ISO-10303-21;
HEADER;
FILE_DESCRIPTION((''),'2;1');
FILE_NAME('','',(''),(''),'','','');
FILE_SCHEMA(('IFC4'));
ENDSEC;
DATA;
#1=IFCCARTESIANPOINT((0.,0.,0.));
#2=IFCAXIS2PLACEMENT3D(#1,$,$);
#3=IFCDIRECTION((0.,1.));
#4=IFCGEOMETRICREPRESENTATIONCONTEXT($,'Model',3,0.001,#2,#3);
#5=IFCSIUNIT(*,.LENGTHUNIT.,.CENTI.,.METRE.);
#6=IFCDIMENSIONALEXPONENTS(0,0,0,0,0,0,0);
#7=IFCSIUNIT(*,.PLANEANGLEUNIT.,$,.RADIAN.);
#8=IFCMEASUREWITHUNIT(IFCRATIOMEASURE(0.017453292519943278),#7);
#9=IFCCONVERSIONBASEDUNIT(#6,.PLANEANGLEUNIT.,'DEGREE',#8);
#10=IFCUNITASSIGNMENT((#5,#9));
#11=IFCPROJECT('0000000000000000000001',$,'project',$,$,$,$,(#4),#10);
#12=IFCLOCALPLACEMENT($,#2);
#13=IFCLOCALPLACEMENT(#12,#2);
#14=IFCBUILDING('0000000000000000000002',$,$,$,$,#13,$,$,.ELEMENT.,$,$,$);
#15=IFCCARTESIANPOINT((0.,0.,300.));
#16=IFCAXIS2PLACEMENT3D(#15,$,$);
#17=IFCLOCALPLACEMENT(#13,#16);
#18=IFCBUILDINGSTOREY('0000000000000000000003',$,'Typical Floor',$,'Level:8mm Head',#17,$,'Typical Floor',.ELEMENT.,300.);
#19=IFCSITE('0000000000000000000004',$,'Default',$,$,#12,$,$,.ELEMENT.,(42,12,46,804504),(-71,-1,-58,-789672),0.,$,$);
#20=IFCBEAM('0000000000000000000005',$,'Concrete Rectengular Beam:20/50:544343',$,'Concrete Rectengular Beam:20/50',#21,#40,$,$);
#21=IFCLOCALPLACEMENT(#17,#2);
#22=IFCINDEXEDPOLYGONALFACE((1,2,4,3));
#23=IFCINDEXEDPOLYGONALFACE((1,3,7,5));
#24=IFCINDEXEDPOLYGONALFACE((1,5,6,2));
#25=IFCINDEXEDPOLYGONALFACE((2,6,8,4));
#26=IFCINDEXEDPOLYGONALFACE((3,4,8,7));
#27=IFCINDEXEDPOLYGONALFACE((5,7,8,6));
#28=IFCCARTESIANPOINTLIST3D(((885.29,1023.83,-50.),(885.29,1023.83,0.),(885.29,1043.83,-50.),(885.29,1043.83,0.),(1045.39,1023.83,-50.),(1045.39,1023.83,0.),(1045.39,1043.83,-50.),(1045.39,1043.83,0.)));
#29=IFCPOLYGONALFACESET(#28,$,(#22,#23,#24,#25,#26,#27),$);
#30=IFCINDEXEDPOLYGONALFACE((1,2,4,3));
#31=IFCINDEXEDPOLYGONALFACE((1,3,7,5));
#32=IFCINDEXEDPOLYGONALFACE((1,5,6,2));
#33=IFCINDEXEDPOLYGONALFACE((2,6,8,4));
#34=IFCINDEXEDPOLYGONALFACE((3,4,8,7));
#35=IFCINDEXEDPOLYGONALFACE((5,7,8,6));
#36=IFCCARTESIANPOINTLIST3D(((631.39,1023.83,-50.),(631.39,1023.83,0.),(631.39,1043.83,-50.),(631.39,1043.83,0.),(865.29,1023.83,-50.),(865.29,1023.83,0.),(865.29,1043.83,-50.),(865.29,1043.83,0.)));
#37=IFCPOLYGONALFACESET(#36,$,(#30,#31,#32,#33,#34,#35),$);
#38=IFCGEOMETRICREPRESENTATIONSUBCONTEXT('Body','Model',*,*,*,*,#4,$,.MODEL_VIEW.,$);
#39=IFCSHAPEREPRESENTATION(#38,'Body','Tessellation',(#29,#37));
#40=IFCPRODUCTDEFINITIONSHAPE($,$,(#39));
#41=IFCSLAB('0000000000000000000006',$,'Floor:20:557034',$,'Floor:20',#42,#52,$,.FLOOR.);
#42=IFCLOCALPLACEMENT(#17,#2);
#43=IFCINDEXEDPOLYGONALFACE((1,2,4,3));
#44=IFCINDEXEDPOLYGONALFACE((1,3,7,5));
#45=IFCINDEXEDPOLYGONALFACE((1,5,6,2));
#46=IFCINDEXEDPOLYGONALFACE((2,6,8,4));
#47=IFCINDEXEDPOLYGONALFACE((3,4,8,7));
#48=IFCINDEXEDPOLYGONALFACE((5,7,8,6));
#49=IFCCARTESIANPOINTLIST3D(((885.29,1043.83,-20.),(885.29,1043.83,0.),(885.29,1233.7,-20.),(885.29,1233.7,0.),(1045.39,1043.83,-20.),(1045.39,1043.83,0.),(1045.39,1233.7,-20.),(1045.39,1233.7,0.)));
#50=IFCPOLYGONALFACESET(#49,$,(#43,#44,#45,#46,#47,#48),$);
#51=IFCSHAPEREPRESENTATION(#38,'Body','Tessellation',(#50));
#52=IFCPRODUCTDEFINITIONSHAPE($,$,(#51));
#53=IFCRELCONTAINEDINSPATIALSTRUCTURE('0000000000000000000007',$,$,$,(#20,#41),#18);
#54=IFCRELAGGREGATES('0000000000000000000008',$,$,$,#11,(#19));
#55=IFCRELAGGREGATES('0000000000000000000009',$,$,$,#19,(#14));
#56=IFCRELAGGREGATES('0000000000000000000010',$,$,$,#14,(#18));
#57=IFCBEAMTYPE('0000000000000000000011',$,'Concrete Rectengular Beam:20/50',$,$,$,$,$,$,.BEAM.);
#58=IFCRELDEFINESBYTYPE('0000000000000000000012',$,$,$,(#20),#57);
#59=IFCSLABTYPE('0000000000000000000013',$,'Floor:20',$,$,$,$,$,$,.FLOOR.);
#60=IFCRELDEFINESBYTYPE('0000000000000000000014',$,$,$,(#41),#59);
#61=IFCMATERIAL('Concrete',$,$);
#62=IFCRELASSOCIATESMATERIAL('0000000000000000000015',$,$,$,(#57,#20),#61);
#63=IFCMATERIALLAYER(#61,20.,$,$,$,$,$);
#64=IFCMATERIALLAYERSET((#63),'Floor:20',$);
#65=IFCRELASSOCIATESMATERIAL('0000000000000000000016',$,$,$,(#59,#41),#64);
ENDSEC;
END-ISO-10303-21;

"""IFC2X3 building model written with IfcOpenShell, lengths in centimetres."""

from ifc_helpers import new_model, entity, si_unit, converted_unit, direction, frame, frame_2d, origin, place, context, subcontext, project, spatial, rectangle, extrude, source, transform, mapped, material, layer, layer_set, layer_usage, type_object, type_shapes, element, save


model = new_model("IFC2X3")

# Units and contexts
model_context = context("Model", 3, precision=0.001, world=origin(), true_north=direction((0.0, 1.0)))
body_context = subcontext(model_context, "Body", "Model", "MODEL_VIEW")
ifc_project = project(units=[si_unit("LENGTHUNIT", "METRE", prefix="CENTI"), converted_unit("PLANEANGLEUNIT", "DEGREE", entity("IfcRatioMeasure", 0.017453292519943278), si_unit("PLANEANGLEUNIT", "RADIAN"), dimensions=[0, 0, 0, 0, 0, 0, 0])], contexts=[model_context])

# Site, building, storey
site_placement = place(None, origin())
site = spatial("IfcSite", under=ifc_project, at=site_placement, Name="Default", CompositionType="ELEMENT", RefLatitude=(42, 12, 46, 804504), RefLongitude=(-71, -1, -58, -789672), RefElevation=0.0)
building_placement = place(site_placement, origin())
building = spatial("IfcBuilding", under=site, at=building_placement, CompositionType="ELEMENT")
storey_placement = place(building_placement, frame((0.0, 0.0, 300.0)))
storey = spatial("IfcBuildingStorey", under=building, at=storey_placement, Name="Typical Floor", ObjectType="Level:8mm Head", LongName="Typical Floor", CompositionType="ELEMENT", Elevation=300.0)

# Beam
ifc_material = material(Name="Concrete")
beam_type_1 = type_object("IfcBeamType", Name="Concrete Rectengular Beam:20/50", PredefinedType="BEAM", material=ifc_material)
shared_shape = source(origin(), body_context, "Body", "SweptSolid", [
    extrude(rectangle(XDim=50.0, YDim=20.0, at=frame_2d((0.0, 0.0), x_axis=(1.0, 0.0))), frame((1045.39, 1033.83, 275.0), z_axis=(-1.0, 0.0, 0.0), x_axis=(0.0, 0.0, -1.0)), (0.0, 0.0, 1.0), 160.1),
    extrude(rectangle(XDim=50.0, YDim=20.0, at=frame_2d((0.0, 0.0), x_axis=(1.0, 0.0))), frame((865.29, 1033.83, 275.0), z_axis=(-1.0, 0.0, 0.0), x_axis=(0.0, 0.0, -1.0)), (0.0, 0.0, 1.0), 233.9),
])
type_shapes(beam_type_1, [shared_shape])
beam_1_placement = place(storey_placement, frame((0.0, 0.0, -300.0)))
element("IfcBeam", 1, at=beam_1_placement, inside=storey, type_object=beam_type_1, material=ifc_material, Name="Concrete Rectengular Beam:20/50:544343", ObjectType="Concrete Rectengular Beam:20/50", context=body_context, shape_type="MappedRepresentation", body=[
    mapped(shared_shape, transform((0.0, 0.0, 0.0), scale=1.0)),
])

# Slab
ifc_layer = layer(ifc_material, 20.0)
ifc_layer_set = layer_set([ifc_layer], Name="Floor:20")
ifc_layer_usage_1 = layer_usage(ifc_layer_set, "AXIS3", "POSITIVE", 0.0)
slab_type_1 = type_object("IfcSlabType", Name="Floor:20", PredefinedType="FLOOR", material=ifc_layer_set)
slab_1_placement = place(storey_placement, origin())
element("IfcSlab", 2, at=slab_1_placement, inside=storey, type_object=slab_type_1, material=ifc_layer_usage_1, Name="Floor:20:557034", ObjectType="Floor:20", PredefinedType="FLOOR", context=body_context, shape_type="SweptSolid", body=[
    extrude(rectangle(XDim=189.88, YDim=160.1, at=frame_2d((0.0, 0.0), x_axis=(1.0, 0.0))), frame((965.34, 1138.76, 0.0), z_axis=(0.0, 0.0, -1.0), x_axis=(0.0, 1.0, 0.0)), (0.0, 0.0, 1.0), 20.0),
])

save(model, "model.ifc")
